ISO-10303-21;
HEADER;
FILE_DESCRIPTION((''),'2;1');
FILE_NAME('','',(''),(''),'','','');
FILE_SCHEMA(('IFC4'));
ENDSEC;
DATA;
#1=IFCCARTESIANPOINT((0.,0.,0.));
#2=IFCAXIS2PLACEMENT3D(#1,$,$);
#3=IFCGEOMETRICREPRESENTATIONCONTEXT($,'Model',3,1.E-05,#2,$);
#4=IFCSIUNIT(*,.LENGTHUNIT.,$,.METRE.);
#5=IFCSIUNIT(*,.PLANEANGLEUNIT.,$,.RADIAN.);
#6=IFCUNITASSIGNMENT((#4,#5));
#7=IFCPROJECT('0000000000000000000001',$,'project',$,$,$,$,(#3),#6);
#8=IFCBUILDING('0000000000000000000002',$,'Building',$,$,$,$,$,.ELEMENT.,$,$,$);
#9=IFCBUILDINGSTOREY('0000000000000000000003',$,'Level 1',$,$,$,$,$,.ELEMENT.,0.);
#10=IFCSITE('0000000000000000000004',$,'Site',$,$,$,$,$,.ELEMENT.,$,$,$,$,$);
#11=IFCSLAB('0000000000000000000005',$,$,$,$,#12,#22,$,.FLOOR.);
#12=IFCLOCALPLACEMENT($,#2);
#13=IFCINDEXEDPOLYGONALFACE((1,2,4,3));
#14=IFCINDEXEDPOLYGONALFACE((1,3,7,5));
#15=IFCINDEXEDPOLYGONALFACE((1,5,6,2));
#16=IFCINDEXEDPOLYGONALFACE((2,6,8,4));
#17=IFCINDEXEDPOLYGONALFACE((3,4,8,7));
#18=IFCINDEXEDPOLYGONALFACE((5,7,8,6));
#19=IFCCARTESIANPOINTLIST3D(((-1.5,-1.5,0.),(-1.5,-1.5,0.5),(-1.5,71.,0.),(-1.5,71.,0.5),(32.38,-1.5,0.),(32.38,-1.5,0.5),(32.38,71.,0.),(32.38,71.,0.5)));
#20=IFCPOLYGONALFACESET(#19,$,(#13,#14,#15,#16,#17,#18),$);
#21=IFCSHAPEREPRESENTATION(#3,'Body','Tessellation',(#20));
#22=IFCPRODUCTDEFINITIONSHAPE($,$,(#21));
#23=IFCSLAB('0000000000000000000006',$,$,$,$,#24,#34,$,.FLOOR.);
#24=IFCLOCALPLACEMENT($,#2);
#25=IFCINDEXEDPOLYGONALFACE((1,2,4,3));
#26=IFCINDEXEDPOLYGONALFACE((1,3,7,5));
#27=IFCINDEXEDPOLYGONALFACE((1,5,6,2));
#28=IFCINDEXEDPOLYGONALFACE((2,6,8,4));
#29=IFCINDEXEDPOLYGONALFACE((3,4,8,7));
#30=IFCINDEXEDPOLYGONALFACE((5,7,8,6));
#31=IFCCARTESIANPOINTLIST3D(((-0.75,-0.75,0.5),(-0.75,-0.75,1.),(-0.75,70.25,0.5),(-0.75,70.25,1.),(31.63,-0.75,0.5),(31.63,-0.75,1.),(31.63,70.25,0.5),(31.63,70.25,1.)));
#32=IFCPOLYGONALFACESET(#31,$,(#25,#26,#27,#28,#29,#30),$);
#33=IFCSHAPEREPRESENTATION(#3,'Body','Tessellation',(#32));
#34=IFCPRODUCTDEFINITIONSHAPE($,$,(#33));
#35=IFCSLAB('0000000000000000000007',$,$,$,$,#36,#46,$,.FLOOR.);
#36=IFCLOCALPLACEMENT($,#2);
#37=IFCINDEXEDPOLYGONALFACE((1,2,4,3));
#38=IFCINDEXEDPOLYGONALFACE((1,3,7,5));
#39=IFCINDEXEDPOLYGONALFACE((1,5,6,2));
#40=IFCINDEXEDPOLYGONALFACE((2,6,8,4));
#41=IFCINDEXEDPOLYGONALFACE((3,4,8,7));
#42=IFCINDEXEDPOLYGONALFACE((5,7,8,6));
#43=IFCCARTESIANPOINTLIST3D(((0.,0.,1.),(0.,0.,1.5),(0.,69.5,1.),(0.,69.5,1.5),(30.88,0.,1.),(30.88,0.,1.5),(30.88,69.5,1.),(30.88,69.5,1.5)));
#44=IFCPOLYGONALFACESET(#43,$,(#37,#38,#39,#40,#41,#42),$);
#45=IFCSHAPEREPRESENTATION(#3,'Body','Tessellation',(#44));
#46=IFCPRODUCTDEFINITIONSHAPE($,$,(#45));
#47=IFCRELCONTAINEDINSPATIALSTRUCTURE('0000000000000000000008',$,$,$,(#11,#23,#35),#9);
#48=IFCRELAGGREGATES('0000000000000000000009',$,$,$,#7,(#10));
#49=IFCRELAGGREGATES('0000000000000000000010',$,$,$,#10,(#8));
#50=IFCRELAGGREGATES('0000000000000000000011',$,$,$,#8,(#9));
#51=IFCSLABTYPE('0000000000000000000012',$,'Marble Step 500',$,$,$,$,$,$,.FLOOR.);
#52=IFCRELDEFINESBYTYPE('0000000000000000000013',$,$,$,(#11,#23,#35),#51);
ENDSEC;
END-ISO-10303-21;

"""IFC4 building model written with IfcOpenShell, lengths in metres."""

from ifc_helpers import new_model, si_unit, frame, origin, place, context, project, spatial, polyline, outline, extrude, type_object, element, save


model = new_model("IFC4")

# Units and contexts
model_context = context("Model", 3, precision=1e-05, world=origin())
ifc_project = project(units=[si_unit("LENGTHUNIT", "METRE"), si_unit("PLANEANGLEUNIT", "RADIAN")], contexts=[model_context])

# Site, building, storey
site = spatial("IfcSite", under=ifc_project, Name="Site", CompositionType="ELEMENT")
building = spatial("IfcBuilding", under=site, Name="Building", CompositionType="ELEMENT")
storey = spatial("IfcBuildingStorey", under=building, Name="Level 1", CompositionType="ELEMENT", Elevation=0.0)

# Slabs
slab_type = type_object("IfcSlabType", Name="Marble Step 500", PredefinedType="FLOOR")
slab_1_placement = place(None, frame((0.0, 0.0, 0.5)))
element("IfcSlab", 1, at=slab_1_placement, inside=storey, type_object=slab_type, PredefinedType="FLOOR", context=model_context, shape_type="SweptSolid", body=[
    extrude(outline(polyline([(-1.5, -1.5), (32.38, -1.5), (32.38, 71.0), (-1.5, 71.0), (-1.5, -1.5)])), origin(), (0.0, 0.0, -1.0), 0.5),
])
slab_2_placement = place(None, frame((0.0, 0.0, 1.0)))
element("IfcSlab", 2, at=slab_2_placement, inside=storey, type_object=slab_type, PredefinedType="FLOOR", context=model_context, shape_type="SweptSolid", body=[
    extrude(outline(polyline([(-0.75, -0.75), (31.63, -0.75), (31.63, 70.25), (-0.75, 70.25), (-0.75, -0.75)])), origin(), (0.0, 0.0, -1.0), 0.5),
])
slab_3_placement = place(None, frame((0.0, 0.0, 1.5)))
element("IfcSlab", 3, at=slab_3_placement, inside=storey, type_object=slab_type, PredefinedType="FLOOR", context=model_context, shape_type="SweptSolid", body=[
    extrude(outline(polyline([(0.0, 0.0), (30.88, 0.0), (30.88, 69.5), (0.0, 69.5), (0.0, 0.0)])), origin(), (0.0, 0.0, -1.0), 0.5),
])

save(model, "model.ifc")
